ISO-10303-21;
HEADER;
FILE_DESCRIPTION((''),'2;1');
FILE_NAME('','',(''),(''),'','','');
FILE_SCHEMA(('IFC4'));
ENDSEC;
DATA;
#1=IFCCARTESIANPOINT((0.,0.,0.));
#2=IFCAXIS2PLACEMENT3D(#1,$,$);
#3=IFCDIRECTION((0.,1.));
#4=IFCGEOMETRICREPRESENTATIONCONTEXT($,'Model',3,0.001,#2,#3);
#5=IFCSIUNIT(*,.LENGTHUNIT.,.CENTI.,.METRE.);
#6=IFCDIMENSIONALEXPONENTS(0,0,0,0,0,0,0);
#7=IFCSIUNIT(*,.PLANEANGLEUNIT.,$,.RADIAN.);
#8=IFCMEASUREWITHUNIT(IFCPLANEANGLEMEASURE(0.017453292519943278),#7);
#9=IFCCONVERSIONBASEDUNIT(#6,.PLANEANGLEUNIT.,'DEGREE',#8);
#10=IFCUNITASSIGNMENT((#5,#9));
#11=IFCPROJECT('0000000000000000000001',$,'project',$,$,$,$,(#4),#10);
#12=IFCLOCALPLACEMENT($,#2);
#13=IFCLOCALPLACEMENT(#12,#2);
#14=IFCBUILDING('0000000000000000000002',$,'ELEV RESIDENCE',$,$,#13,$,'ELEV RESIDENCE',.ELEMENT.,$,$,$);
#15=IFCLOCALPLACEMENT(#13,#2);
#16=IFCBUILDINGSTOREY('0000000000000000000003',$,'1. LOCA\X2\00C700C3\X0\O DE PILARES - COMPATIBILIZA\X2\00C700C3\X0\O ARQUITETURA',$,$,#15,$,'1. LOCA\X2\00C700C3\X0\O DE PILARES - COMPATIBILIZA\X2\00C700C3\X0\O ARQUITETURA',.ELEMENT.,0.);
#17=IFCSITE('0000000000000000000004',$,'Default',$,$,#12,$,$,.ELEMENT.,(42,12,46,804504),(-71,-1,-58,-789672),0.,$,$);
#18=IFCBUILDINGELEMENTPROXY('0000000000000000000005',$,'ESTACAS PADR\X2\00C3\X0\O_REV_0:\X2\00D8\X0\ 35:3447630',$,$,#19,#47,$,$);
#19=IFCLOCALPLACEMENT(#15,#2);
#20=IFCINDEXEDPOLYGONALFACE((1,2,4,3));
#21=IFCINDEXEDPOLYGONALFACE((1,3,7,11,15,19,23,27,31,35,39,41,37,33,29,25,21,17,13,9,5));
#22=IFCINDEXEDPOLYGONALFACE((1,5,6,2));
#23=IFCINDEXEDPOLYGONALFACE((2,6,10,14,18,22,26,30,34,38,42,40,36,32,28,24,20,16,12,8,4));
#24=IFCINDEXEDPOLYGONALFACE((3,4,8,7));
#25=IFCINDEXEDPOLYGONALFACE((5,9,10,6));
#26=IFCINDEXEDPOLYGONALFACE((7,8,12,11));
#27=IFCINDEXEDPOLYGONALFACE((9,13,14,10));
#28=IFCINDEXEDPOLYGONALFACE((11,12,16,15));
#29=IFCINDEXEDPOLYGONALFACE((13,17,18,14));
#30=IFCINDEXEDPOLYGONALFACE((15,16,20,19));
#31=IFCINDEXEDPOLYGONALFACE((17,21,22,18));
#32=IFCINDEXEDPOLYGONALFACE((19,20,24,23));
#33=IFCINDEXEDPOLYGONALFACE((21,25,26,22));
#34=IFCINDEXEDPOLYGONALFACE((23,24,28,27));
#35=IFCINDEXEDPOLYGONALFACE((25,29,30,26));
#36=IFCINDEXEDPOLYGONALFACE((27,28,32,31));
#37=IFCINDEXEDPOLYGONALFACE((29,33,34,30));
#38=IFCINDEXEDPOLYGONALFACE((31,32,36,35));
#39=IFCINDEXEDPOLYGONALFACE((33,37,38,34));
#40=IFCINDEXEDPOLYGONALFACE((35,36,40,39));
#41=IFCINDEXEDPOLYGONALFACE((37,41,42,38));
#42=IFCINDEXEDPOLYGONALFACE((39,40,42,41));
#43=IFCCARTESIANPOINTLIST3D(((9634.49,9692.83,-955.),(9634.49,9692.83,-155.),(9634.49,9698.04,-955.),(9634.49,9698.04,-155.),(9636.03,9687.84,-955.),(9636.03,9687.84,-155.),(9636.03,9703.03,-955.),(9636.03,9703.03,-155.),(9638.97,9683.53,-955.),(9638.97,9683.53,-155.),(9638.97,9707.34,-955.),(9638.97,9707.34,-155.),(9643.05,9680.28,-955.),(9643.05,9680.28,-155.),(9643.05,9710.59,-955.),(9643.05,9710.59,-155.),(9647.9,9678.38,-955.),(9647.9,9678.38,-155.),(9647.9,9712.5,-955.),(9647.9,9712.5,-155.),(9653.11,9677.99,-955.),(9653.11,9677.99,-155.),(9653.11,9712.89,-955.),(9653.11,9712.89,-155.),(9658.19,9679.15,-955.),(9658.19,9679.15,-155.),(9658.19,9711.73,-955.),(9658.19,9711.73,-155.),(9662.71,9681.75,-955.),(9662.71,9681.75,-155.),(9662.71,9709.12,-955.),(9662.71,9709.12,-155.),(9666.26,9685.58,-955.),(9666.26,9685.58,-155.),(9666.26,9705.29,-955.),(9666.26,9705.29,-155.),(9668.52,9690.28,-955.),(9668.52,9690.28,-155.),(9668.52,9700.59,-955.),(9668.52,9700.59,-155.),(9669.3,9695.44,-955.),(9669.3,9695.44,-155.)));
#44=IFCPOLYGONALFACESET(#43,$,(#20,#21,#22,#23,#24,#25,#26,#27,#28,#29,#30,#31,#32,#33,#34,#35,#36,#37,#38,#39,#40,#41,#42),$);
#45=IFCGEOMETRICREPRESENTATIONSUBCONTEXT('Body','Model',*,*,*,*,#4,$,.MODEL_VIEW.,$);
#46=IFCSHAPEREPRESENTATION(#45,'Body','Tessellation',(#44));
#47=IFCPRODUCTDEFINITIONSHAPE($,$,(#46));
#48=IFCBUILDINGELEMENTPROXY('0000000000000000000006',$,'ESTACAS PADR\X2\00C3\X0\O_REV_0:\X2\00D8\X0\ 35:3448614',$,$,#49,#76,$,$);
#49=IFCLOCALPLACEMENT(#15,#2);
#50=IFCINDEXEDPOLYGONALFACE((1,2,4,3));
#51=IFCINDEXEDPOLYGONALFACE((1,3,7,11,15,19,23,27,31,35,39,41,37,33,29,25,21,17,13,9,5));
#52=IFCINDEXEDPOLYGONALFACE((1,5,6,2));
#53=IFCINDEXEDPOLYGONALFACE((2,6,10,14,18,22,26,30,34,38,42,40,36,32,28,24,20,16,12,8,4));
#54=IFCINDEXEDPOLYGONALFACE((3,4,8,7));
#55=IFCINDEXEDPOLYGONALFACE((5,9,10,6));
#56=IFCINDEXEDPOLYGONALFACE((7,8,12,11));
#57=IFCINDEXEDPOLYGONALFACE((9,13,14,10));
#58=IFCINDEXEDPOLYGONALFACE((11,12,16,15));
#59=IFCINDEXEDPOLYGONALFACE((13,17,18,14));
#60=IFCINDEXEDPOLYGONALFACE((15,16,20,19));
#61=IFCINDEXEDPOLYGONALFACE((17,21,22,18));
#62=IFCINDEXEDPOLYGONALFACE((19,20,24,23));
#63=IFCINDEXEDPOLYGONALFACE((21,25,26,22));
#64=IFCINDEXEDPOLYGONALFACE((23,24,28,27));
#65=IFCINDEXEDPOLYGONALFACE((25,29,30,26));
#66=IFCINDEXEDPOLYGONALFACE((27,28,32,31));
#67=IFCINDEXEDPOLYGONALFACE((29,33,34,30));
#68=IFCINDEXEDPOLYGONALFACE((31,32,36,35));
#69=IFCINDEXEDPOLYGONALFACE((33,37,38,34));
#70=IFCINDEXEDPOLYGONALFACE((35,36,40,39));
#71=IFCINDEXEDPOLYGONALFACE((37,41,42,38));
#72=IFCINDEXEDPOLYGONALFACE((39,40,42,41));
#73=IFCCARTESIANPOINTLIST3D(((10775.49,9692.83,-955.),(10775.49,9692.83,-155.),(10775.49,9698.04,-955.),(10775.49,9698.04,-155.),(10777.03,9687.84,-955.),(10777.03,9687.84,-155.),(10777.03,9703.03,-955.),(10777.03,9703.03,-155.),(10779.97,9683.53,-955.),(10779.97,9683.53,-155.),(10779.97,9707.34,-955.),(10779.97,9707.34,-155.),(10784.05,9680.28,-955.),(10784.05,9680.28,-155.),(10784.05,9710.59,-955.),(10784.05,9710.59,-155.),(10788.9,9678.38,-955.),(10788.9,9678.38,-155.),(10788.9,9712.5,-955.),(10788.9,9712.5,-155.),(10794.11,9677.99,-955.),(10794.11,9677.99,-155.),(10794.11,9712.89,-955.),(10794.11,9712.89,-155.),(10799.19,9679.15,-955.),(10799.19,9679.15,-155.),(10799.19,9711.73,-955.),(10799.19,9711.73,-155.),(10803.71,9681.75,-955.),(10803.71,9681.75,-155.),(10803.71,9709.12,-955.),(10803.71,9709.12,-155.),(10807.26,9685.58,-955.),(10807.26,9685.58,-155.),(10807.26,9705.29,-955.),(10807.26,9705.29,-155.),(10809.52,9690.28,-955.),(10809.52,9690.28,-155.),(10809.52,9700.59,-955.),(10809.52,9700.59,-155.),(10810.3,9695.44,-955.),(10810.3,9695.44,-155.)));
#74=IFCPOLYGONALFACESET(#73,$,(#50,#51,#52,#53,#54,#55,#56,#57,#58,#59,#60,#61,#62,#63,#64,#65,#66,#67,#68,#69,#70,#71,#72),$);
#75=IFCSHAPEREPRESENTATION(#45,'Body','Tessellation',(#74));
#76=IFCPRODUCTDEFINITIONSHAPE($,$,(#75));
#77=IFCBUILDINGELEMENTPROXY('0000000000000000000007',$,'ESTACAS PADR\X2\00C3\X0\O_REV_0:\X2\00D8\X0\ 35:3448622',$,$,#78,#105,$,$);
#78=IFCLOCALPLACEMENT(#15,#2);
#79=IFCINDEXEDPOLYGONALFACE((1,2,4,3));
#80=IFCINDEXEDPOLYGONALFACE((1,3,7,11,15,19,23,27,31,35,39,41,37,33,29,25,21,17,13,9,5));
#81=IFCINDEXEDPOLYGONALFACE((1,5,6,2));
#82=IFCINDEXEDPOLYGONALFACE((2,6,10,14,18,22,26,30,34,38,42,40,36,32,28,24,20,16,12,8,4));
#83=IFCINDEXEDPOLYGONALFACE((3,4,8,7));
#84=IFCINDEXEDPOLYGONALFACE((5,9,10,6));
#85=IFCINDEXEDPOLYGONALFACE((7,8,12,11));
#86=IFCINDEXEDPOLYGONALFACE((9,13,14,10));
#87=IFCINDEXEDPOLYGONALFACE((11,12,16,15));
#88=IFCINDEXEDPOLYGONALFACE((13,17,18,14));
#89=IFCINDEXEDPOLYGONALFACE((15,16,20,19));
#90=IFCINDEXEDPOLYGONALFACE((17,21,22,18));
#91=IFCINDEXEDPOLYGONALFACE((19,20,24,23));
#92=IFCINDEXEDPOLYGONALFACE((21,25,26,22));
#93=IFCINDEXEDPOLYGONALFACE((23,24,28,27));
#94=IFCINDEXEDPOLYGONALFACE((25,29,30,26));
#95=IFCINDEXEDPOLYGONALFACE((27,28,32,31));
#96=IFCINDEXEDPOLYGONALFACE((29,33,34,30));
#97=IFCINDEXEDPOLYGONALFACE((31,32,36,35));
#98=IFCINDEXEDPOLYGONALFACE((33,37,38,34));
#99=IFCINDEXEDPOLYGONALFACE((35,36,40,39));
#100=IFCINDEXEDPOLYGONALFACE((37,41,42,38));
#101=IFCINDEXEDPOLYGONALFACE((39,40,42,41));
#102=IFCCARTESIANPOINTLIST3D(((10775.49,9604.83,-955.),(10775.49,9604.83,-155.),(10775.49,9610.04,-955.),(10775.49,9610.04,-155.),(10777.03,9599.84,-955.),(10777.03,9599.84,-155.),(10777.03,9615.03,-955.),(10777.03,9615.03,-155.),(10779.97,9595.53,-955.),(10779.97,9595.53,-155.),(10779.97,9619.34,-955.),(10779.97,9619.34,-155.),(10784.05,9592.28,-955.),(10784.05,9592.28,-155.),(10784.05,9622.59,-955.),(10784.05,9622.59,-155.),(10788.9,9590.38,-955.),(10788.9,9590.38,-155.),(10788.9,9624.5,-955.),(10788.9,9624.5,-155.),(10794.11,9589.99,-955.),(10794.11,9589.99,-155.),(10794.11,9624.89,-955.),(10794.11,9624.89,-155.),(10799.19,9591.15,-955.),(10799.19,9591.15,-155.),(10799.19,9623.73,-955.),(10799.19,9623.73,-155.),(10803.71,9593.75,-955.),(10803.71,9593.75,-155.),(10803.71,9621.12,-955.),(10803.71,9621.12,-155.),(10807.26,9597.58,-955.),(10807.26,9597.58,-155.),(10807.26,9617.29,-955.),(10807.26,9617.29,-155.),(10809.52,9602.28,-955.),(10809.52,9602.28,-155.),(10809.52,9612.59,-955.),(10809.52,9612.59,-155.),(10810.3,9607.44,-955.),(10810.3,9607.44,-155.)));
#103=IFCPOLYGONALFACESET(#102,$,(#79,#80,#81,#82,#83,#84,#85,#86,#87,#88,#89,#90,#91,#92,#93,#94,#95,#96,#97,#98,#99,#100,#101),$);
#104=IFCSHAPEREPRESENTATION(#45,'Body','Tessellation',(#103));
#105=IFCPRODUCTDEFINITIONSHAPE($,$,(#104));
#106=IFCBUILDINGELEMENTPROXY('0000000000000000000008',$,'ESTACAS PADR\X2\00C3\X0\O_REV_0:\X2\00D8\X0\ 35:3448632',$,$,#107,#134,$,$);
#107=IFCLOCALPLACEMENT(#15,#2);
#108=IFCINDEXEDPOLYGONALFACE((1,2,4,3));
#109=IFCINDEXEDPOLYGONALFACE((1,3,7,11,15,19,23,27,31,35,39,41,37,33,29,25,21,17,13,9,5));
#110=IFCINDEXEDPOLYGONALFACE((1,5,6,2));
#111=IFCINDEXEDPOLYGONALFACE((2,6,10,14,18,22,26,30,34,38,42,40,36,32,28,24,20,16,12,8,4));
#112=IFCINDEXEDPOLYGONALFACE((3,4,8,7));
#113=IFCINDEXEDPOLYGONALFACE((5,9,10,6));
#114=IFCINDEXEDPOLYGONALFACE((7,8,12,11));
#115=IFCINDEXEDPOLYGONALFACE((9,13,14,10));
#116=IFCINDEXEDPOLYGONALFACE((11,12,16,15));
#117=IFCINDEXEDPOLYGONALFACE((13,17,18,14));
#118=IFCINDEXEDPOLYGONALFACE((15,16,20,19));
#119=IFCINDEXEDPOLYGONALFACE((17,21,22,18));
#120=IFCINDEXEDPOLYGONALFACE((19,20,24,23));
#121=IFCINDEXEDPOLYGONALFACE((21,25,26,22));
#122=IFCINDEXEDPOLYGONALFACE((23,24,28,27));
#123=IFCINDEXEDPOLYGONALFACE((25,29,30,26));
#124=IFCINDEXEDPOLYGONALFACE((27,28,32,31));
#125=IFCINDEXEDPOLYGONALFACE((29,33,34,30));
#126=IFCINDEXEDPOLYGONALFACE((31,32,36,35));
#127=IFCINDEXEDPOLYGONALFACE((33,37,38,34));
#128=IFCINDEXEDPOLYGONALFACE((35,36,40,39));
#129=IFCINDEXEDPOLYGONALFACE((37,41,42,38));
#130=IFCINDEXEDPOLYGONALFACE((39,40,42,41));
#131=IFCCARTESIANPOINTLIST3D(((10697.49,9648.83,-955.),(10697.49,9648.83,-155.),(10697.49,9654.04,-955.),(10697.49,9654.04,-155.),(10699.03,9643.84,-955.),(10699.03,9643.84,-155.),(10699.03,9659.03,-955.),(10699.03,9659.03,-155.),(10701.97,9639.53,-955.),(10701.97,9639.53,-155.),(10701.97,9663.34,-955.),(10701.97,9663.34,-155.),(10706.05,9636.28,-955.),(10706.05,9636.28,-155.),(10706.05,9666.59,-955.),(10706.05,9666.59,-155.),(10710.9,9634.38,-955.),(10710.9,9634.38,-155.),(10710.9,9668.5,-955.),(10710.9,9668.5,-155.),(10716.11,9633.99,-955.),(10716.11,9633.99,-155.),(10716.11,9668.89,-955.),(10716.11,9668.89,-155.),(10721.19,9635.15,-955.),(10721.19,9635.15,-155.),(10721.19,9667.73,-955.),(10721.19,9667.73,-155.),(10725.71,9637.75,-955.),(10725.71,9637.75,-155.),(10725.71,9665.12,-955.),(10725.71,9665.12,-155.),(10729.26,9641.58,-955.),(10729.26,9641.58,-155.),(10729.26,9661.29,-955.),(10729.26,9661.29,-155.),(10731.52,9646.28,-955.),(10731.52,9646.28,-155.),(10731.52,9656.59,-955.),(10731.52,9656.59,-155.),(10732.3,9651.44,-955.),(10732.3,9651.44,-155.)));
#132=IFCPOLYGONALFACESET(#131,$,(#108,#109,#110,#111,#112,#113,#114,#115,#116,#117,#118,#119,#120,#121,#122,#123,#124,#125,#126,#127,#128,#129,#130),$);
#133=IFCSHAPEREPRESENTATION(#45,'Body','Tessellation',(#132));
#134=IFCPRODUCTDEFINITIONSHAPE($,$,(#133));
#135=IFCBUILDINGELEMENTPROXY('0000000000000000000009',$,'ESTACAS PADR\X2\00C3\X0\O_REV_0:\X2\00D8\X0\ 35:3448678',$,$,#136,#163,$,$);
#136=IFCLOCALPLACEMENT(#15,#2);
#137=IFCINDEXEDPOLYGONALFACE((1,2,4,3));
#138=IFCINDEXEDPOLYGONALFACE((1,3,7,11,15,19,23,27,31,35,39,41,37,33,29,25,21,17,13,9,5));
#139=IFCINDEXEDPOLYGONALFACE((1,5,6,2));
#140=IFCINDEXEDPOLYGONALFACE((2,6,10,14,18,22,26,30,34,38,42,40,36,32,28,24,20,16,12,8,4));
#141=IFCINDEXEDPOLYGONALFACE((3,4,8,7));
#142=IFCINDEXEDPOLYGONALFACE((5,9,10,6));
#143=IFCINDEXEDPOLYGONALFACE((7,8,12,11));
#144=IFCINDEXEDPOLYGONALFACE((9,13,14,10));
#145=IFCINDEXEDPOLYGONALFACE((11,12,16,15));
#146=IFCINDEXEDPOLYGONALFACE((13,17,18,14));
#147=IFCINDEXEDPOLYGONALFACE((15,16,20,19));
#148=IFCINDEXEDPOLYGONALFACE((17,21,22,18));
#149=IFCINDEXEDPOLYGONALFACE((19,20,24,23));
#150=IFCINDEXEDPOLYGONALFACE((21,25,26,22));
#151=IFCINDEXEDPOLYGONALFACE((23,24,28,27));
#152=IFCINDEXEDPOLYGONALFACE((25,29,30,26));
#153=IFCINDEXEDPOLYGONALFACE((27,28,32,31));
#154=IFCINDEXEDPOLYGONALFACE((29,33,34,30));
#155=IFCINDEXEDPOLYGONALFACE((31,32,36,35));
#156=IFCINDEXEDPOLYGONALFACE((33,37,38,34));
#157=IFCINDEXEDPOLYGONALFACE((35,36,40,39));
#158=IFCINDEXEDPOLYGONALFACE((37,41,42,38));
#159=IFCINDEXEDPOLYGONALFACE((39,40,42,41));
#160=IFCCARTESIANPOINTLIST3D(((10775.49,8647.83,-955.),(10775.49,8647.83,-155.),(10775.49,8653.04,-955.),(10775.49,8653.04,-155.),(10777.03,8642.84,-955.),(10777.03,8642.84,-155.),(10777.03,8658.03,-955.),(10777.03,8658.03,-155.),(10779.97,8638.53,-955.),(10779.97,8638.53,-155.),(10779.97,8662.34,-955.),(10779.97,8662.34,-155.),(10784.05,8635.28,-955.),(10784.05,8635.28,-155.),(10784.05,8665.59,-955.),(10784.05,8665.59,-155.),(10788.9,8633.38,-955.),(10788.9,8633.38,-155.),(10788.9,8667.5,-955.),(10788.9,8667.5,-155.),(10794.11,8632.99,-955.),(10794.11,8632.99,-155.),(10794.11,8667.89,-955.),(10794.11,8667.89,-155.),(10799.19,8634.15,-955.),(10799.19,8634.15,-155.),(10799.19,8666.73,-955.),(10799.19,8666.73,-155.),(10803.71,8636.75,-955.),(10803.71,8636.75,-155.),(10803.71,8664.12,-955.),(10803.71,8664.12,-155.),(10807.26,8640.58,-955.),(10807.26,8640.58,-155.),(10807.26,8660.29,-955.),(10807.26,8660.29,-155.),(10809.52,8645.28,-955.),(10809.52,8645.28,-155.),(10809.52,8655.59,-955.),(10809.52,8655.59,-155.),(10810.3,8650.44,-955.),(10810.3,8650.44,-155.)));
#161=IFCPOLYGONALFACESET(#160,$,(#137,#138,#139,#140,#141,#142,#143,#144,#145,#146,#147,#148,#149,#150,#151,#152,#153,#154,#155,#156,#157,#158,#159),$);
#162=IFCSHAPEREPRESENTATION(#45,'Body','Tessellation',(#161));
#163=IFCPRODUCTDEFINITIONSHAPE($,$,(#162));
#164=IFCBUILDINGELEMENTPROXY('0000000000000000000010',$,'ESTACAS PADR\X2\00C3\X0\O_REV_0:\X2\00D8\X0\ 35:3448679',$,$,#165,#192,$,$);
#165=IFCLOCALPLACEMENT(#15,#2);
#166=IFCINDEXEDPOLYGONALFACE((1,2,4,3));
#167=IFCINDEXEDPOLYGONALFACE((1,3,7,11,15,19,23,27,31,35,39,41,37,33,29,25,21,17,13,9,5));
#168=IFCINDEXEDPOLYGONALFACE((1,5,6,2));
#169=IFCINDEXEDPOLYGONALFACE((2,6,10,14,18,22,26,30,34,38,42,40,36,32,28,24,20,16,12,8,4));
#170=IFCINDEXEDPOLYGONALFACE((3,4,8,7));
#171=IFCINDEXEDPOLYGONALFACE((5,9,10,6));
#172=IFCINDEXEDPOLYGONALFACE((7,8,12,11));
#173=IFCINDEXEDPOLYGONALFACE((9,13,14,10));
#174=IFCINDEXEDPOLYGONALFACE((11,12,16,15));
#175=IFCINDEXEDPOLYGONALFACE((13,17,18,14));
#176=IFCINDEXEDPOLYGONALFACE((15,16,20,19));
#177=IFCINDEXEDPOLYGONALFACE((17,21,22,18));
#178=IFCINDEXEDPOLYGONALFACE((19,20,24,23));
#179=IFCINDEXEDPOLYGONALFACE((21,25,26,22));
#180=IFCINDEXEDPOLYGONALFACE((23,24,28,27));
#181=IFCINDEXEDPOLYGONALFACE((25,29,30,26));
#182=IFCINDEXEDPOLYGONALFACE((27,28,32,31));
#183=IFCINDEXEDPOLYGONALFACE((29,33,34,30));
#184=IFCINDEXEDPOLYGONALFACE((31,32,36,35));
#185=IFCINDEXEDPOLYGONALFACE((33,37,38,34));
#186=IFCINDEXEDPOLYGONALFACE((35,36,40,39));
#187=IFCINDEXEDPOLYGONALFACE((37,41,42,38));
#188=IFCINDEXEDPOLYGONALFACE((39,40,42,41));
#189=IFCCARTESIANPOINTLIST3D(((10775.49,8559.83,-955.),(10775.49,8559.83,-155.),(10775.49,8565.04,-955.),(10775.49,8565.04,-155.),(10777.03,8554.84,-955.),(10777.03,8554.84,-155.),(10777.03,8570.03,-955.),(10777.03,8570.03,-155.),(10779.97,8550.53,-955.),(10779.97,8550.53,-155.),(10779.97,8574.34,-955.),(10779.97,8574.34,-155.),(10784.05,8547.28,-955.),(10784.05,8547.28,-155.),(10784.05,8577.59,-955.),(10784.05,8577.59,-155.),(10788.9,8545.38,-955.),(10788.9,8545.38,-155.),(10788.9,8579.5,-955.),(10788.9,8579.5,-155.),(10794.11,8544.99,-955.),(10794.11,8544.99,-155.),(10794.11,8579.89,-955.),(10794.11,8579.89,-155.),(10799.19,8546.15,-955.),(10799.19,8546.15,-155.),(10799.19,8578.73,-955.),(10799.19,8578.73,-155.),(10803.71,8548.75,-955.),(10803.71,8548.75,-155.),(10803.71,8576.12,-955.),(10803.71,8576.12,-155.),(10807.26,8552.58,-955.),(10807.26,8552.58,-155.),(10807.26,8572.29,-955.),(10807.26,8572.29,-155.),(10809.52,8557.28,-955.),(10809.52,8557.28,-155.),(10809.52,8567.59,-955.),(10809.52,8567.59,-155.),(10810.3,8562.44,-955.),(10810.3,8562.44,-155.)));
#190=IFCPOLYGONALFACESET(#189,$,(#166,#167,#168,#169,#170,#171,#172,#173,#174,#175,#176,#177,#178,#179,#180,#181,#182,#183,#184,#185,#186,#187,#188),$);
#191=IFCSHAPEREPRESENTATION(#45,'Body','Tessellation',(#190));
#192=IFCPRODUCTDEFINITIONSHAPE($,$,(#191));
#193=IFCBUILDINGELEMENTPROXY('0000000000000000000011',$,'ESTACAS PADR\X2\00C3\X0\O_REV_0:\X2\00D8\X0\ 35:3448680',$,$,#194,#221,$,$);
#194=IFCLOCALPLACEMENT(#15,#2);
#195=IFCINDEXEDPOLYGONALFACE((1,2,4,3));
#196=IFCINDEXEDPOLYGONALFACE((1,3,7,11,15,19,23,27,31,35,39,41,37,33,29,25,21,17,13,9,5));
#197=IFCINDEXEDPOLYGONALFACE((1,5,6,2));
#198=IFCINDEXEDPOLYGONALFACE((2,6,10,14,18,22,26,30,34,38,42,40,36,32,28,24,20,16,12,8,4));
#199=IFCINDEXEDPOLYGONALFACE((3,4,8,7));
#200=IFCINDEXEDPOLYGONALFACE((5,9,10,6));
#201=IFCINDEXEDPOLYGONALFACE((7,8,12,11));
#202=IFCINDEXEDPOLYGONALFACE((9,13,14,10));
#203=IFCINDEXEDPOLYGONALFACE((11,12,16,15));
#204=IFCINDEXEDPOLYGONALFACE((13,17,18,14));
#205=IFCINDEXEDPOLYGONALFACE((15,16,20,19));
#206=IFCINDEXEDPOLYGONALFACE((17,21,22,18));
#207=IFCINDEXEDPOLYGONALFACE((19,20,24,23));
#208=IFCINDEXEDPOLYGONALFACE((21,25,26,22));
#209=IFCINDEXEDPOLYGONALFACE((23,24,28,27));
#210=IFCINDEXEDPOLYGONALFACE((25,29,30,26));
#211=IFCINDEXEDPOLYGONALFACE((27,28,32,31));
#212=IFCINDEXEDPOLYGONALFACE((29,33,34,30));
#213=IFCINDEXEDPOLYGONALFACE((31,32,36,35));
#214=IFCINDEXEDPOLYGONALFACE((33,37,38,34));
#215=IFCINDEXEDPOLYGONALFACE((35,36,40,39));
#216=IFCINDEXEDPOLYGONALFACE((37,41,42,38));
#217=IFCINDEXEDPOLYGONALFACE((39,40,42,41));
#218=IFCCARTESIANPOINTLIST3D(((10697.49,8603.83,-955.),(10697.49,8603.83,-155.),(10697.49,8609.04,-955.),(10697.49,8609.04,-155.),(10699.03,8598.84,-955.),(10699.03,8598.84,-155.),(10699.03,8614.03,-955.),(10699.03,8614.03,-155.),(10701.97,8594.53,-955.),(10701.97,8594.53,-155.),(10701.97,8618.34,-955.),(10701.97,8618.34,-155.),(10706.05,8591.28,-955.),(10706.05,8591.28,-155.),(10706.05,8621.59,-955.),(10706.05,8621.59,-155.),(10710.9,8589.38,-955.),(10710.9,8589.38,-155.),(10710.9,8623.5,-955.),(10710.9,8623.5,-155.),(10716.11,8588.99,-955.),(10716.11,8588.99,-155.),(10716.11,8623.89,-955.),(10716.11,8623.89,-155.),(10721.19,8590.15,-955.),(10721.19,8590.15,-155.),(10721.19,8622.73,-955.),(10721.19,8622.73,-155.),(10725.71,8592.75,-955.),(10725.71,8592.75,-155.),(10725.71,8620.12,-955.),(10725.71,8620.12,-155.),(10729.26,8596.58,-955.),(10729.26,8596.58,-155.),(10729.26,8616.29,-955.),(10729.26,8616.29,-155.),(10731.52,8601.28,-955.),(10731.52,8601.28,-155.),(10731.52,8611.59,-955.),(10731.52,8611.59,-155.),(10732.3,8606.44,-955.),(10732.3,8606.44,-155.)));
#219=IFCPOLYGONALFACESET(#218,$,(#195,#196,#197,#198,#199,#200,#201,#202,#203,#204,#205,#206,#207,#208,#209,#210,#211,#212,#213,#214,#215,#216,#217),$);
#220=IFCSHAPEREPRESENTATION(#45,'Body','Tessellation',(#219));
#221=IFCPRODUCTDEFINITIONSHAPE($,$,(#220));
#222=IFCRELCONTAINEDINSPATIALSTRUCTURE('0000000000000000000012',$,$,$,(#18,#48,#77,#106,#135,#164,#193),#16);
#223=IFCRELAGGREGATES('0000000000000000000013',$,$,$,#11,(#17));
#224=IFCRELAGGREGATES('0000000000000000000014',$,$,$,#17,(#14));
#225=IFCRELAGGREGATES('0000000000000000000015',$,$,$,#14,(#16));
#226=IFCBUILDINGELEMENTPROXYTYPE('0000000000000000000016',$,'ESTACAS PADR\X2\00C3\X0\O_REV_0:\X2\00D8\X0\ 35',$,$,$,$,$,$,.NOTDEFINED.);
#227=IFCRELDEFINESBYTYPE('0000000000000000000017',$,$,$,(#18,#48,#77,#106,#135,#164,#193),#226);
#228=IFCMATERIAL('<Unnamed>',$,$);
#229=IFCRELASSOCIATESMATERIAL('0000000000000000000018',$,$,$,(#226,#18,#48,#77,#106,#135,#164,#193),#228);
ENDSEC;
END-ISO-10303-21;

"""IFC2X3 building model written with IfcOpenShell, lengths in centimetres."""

from ifc_helpers import new_model, entity, si_unit, converted_unit, direction, frame, frame_2d, origin, place, context, subcontext, project, spatial, circle, extrude, source, transform, mapped, material, type_object, type_shapes, element, save


model = new_model("IFC2X3")

# Units and contexts
model_context = context("Model", 3, precision=0.001, world=origin(), true_north=direction((0.0, 1.0)))
body_context = subcontext(model_context, "Body", "Model", "MODEL_VIEW")
ifc_project = project(units=[si_unit("LENGTHUNIT", "METRE", prefix="CENTI"), converted_unit("PLANEANGLEUNIT", "DEGREE", entity("IfcPlaneAngleMeasure", 0.017453292519943278), si_unit("PLANEANGLEUNIT", "RADIAN"), dimensions=[0, 0, 0, 0, 0, 0, 0])], contexts=[model_context])

# Site, building, storey
site_placement = place(None, origin())
site = spatial("IfcSite", under=ifc_project, at=site_placement, Name="Default", CompositionType="ELEMENT", RefLatitude=(42, 12, 46, 804504), RefLongitude=(-71, -1, -58, -789672), RefElevation=0.0)
building_placement = place(site_placement, origin())
building = spatial("IfcBuilding", under=site, at=building_placement, Name="ELEV RESIDENCE", LongName="ELEV RESIDENCE", CompositionType="ELEMENT")
storey_placement = place(building_placement, origin())
storey = spatial("IfcBuildingStorey", under=building, at=storey_placement, Name="1. LOCAÇÃO DE PILARES - COMPATIBILIZAÇÃO ARQUITETURA", LongName="1. LOCAÇÃO DE PILARES - COMPATIBILIZAÇÃO ARQUITETURA", CompositionType="ELEMENT", Elevation=0.0)

# Building element proxies
ifc_material_1 = material(Name="<Unnamed>")
building_element_proxy_type_1 = type_object("IfcBuildingElementProxyType", Name="ESTACAS PADRÃO_REV_0:Ø 35", PredefinedType="NOTDEFINED", material=ifc_material_1)
shared_shape_1 = source(origin(), body_context, "Body", "SweptSolid", [
    extrude(circle(Radius=17.5, at=frame_2d((0.0, 0.0), x_axis=(1.0, 0.0))), frame((0.0, 0.0, -955.0)), (0.0, 0.0, 1.0), 800.0),
])
type_shapes(building_element_proxy_type_1, [shared_shape_1])
for number, where, name in (
    (1, (9651.8, 9695.44, 0.0), "ESTACAS PADRÃO_REV_0:Ø 35:3447630"),
    (2, (10792.8, 9695.44, 0.0), "ESTACAS PADRÃO_REV_0:Ø 35:3448614"),
    (3, (10792.8, 9607.44, 0.0), "ESTACAS PADRÃO_REV_0:Ø 35:3448622"),
    (4, (10714.8, 9651.44, 0.0), "ESTACAS PADRÃO_REV_0:Ø 35:3448632"),
    (5, (10792.8, 8650.44, 0.0), "ESTACAS PADRÃO_REV_0:Ø 35:3448678"),
    (6, (10792.8, 8562.44, 0.0), "ESTACAS PADRÃO_REV_0:Ø 35:3448679"),
    (7, (10714.8, 8606.44, 0.0), "ESTACAS PADRÃO_REV_0:Ø 35:3448680"),
):
    element("IfcBuildingElementProxy", number, at=place(storey_placement, frame(where)), inside=storey, type_object=building_element_proxy_type_1, material=ifc_material_1, Name=name, context=body_context, shape_type="MappedRepresentation", body=[
        mapped(shared_shape_1, transform((0.0, 0.0, 0.0), scale=1.0)),
    ])

save(model, "model.ifc")
